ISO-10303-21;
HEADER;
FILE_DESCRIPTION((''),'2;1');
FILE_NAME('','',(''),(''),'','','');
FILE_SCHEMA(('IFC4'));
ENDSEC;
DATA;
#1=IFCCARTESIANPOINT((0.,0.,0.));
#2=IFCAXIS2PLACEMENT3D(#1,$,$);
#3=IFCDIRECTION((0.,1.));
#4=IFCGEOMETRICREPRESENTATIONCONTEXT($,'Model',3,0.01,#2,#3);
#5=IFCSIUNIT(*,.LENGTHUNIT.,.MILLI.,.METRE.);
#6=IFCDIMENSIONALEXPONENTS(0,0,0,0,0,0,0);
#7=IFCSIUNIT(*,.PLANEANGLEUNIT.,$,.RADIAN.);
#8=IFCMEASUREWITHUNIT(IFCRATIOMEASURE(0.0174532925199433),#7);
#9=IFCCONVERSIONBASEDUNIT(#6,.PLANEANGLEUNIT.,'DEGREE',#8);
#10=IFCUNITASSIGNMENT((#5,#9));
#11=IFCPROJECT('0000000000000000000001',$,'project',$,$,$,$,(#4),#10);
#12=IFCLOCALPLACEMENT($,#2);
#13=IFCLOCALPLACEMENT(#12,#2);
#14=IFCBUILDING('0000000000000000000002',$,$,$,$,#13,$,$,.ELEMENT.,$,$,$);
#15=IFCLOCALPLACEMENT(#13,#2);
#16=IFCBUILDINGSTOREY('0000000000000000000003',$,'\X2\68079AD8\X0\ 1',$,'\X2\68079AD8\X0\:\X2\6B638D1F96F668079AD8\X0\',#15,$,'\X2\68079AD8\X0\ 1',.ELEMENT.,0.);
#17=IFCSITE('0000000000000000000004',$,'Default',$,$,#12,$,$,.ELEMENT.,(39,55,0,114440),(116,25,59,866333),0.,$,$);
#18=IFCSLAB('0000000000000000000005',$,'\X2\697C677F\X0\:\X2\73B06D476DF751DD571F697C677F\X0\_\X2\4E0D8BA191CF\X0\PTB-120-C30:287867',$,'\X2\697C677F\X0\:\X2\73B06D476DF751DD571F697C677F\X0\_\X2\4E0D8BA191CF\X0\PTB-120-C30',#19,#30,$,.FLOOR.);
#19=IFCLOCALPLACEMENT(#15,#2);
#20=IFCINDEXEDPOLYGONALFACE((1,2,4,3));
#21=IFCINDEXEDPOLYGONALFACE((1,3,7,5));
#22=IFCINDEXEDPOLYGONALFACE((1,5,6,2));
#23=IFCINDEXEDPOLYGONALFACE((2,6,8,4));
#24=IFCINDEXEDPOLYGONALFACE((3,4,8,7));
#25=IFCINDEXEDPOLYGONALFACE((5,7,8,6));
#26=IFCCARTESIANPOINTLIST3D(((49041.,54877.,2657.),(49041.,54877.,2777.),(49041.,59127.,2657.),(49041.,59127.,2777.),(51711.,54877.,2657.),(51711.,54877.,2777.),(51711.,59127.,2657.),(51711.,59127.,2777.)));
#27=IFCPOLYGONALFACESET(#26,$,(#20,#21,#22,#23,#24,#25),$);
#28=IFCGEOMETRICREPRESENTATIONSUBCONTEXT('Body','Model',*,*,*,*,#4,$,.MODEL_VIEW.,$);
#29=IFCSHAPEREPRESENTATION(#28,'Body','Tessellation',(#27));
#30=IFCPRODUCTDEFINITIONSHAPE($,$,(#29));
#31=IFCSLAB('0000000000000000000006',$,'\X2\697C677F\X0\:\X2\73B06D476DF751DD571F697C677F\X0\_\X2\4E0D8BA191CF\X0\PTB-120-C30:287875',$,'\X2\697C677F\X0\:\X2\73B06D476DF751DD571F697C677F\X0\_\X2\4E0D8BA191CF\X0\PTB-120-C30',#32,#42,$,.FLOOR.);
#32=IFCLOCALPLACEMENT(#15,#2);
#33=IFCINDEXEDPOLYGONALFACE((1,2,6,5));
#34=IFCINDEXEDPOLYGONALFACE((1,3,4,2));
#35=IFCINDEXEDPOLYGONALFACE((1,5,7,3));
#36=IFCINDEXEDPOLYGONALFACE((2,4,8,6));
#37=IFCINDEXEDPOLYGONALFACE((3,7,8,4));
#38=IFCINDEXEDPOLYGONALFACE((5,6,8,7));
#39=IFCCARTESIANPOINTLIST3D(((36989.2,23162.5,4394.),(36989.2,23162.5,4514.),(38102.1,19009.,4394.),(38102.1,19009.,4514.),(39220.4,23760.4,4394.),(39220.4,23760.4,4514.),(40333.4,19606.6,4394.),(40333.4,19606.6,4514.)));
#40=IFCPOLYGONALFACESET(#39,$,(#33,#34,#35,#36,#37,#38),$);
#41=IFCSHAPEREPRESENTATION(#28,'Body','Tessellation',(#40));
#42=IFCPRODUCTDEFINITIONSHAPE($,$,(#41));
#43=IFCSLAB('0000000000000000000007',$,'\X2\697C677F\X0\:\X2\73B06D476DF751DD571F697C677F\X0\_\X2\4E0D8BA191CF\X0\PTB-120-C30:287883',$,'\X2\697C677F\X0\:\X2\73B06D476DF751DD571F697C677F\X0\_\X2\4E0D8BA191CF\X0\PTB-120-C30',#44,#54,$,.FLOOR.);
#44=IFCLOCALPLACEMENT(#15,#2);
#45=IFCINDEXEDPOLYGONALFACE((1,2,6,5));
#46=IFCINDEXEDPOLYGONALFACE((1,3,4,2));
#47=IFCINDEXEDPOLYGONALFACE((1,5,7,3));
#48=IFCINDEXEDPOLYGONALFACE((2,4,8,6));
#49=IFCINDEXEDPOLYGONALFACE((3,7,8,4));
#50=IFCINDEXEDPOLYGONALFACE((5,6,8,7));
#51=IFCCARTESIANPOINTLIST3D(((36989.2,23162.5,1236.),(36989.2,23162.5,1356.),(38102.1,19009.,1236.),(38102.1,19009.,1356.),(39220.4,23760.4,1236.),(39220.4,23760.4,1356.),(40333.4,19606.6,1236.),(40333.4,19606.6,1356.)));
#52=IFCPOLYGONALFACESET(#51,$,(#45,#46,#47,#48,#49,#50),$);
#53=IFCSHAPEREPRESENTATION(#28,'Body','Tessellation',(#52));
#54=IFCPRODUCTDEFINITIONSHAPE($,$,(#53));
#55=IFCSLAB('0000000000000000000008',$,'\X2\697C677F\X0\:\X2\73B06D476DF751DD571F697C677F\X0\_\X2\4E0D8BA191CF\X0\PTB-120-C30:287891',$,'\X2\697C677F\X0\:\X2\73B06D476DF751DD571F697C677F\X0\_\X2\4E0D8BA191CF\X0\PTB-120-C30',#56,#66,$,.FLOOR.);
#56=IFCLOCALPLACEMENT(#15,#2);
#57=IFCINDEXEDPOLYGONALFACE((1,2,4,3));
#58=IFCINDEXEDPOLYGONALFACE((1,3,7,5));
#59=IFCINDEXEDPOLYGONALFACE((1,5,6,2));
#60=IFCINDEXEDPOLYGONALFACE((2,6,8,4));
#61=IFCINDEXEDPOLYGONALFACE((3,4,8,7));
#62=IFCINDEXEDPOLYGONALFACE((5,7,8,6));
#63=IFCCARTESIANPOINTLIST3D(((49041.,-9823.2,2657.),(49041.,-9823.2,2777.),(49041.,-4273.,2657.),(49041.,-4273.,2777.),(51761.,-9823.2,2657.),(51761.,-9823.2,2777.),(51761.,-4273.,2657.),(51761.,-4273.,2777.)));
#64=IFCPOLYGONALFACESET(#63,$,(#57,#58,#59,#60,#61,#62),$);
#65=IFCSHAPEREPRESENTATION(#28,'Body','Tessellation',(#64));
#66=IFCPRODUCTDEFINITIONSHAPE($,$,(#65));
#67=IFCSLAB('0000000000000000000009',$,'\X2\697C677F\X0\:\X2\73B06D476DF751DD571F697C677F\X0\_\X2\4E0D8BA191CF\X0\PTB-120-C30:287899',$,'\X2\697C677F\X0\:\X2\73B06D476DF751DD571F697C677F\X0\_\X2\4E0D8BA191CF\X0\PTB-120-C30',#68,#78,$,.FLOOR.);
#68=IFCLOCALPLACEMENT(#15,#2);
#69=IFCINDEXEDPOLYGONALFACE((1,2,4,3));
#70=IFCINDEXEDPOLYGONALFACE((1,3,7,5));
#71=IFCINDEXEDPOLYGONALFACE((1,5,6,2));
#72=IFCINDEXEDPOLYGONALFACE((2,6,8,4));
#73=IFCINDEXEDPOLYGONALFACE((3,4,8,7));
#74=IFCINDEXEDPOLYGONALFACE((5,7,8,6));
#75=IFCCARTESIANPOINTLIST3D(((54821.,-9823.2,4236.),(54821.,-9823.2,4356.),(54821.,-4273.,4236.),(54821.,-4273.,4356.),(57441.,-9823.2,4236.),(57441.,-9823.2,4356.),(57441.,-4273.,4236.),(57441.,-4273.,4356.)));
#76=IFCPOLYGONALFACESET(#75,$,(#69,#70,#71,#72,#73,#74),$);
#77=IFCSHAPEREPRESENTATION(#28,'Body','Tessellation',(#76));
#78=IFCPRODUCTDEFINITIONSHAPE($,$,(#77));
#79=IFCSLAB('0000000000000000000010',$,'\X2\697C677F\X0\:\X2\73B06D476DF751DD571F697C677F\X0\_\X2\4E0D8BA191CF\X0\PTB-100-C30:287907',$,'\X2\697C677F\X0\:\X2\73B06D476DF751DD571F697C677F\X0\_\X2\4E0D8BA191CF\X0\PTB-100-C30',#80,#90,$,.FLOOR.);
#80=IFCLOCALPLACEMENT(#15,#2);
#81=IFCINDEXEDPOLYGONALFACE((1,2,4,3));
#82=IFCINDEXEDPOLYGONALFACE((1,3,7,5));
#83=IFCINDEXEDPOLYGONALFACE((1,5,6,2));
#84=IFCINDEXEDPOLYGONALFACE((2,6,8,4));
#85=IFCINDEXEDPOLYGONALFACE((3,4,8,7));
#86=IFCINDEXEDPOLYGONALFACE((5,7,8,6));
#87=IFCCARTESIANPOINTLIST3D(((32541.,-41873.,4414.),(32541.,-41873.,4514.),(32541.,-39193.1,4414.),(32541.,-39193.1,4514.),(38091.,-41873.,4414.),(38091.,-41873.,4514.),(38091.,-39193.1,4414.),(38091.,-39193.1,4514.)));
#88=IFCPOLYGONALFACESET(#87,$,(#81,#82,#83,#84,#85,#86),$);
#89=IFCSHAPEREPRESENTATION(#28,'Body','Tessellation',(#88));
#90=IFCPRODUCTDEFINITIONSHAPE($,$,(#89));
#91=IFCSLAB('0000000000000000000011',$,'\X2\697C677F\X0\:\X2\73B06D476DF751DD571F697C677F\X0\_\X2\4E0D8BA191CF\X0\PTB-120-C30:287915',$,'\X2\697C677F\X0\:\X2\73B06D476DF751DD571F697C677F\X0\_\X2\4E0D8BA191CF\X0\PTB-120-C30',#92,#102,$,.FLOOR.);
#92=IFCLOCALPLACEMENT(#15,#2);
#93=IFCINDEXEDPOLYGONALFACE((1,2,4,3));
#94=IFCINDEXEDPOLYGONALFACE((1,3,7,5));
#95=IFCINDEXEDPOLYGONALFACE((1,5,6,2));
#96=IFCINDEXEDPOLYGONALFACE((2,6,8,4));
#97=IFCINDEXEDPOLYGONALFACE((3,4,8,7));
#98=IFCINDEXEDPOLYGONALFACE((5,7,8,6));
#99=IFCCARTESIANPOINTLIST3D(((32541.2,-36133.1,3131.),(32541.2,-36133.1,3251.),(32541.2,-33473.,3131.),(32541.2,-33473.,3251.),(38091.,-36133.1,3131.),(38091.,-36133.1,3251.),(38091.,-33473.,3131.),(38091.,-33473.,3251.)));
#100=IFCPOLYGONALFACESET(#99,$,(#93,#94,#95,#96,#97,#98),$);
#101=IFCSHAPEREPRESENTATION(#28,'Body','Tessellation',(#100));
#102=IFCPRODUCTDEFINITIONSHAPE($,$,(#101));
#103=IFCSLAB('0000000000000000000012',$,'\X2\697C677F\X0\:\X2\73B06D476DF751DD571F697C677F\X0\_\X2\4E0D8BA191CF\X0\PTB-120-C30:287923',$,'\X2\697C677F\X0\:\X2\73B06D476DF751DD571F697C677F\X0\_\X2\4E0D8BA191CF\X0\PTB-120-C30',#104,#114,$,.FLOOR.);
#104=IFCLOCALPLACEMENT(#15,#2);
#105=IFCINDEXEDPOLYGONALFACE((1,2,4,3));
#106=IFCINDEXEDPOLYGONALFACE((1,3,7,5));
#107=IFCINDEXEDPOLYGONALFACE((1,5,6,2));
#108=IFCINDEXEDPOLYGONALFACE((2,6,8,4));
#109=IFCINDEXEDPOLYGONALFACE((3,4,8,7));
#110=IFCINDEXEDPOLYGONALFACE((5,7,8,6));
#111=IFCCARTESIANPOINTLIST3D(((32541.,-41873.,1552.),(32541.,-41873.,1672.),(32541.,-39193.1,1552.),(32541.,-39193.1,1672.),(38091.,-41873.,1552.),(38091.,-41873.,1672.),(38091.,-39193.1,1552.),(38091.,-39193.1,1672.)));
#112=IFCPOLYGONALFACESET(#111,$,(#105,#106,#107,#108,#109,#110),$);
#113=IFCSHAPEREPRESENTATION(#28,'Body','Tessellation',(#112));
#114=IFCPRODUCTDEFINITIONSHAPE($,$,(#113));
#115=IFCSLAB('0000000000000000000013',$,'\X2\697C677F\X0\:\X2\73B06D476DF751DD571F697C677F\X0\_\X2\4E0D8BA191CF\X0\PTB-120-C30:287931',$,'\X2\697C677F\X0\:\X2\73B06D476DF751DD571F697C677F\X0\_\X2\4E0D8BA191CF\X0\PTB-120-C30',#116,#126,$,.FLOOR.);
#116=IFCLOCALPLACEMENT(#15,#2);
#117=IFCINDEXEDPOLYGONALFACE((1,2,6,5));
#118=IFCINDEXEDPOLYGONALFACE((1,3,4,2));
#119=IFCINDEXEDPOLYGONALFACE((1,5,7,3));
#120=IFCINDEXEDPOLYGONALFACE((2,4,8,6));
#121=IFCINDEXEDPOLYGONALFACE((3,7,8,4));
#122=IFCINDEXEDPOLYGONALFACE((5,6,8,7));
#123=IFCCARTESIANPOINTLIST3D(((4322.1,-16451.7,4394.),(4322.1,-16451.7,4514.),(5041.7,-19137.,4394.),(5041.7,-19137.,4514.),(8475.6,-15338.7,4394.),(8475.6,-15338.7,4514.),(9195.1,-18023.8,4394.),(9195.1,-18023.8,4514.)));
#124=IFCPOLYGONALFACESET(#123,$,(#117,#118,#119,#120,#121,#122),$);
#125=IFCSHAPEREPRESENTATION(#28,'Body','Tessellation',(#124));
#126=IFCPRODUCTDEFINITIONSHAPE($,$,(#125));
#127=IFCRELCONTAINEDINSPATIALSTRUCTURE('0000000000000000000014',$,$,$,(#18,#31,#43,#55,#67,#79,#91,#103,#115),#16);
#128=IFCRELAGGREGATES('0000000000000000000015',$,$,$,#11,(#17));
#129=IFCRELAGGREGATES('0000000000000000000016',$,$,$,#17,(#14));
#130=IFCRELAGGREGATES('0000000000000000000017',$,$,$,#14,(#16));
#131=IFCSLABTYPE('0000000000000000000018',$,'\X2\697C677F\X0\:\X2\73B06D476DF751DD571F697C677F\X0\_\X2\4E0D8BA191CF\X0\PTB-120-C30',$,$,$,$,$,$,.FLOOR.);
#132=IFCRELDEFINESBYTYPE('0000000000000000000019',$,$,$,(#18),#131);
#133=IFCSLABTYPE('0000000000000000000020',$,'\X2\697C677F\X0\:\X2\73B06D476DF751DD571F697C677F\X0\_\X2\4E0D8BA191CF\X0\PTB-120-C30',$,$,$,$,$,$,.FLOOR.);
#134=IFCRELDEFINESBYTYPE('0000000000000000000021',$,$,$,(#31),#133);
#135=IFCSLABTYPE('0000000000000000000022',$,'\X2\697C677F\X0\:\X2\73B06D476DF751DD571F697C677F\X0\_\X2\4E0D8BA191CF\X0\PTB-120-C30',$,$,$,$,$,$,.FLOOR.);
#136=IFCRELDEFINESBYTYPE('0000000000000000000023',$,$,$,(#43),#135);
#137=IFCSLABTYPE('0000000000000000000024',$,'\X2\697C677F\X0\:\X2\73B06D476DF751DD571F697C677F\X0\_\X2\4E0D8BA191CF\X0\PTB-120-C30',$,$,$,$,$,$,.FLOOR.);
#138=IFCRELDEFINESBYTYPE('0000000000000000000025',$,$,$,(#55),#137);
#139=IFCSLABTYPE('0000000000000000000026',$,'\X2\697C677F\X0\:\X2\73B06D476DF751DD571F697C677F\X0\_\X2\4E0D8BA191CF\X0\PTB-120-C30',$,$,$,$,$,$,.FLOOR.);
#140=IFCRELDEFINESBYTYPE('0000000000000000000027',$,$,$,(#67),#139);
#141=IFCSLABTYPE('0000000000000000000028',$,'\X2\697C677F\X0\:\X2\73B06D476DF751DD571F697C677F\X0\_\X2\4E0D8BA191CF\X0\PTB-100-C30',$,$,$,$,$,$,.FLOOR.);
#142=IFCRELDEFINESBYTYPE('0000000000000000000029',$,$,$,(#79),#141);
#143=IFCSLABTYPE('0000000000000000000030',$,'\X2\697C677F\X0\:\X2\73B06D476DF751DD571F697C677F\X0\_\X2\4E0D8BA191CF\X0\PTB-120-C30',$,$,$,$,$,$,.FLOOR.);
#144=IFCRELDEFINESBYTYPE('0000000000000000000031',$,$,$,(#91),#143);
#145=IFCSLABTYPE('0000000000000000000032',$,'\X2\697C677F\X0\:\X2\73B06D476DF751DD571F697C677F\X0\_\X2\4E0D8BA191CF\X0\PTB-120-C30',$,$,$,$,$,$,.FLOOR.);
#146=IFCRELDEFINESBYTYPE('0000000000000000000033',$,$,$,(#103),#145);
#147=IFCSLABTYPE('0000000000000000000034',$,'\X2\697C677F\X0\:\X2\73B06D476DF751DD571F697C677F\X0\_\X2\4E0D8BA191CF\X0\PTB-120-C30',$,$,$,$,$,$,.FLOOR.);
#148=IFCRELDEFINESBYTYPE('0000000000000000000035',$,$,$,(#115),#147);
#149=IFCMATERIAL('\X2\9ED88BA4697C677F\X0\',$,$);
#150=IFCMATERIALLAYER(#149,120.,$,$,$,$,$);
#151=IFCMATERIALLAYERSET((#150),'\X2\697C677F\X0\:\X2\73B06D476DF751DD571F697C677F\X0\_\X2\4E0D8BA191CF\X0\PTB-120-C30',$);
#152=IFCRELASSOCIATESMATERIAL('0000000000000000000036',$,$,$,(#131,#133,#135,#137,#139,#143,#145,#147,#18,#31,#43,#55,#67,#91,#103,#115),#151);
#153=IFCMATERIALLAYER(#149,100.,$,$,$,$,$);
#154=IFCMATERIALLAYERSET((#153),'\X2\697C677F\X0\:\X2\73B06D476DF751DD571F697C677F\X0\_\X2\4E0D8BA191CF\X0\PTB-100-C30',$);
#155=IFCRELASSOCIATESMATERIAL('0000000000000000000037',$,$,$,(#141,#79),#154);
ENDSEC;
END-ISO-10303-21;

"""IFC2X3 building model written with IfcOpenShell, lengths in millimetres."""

from ifc_helpers import new_model, entity, si_unit, converted_unit, direction, frame, frame_2d, origin, place, context, subcontext, project, spatial, polyline, rectangle, outline, extrude, material, layer, layer_set, layer_usage, type_object, element, save


model = new_model("IFC2X3")

# Units and contexts
model_context = context("Model", 3, precision=0.01, world=origin(), true_north=direction((0.0, 1.0)))
body_context = subcontext(model_context, "Body", "Model", "MODEL_VIEW")
ifc_project = project(units=[si_unit("LENGTHUNIT", "METRE", prefix="MILLI"), converted_unit("PLANEANGLEUNIT", "DEGREE", entity("IfcRatioMeasure", 0.0174532925199433), si_unit("PLANEANGLEUNIT", "RADIAN"), dimensions=[0, 0, 0, 0, 0, 0, 0])], contexts=[model_context])

# Site, building, storey
site_placement = place(None, origin())
site = spatial("IfcSite", under=ifc_project, at=site_placement, Name="Default", CompositionType="ELEMENT", RefLatitude=(39, 55, 0, 114440), RefLongitude=(116, 25, 59, 866333), RefElevation=0.0)
building_placement = place(site_placement, origin())
building = spatial("IfcBuilding", under=site, at=building_placement, CompositionType="ELEMENT")
storey_placement = place(building_placement, origin())
storey = spatial("IfcBuildingStorey", under=building, at=storey_placement, Name="标高 1", ObjectType="标高:正负零标高", LongName="标高 1", CompositionType="ELEMENT", Elevation=0.0)

# Slabs
ifc_material = material(Name="默认楼板")
ifc_layer_1 = layer(ifc_material, 120.0)
ifc_layer_set_1 = layer_set([ifc_layer_1], Name="楼板:现浇混凝土楼板_不计量PTB-120-C30")
ifc_layer_2 = layer(ifc_material, 100.0)
ifc_layer_set_2 = layer_set([ifc_layer_2], Name="楼板:现浇混凝土楼板_不计量PTB-100-C30")
ifc_layer_usage_1 = layer_usage(ifc_layer_set_1, "AXIS3", "POSITIVE", 0.0)
slab_type_1 = type_object("IfcSlabType", Name="楼板:现浇混凝土楼板_不计量PTB-120-C30", PredefinedType="FLOOR", material=ifc_layer_set_1)
slab_1_placement = place(building_placement, origin())
element("IfcSlab", 1, at=slab_1_placement, inside=storey, type_object=slab_type_1, material=ifc_layer_usage_1, Name="楼板:现浇混凝土楼板_不计量PTB-120-C30:287867", ObjectType="楼板:现浇混凝土楼板_不计量PTB-120-C30", PredefinedType="FLOOR", context=body_context, shape_type="SweptSolid", body=[
    extrude(rectangle(XDim=4250.0, YDim=2670.0, at=frame_2d((0.0, 0.0), x_axis=(1.0, 0.0))), frame((50376.0, 57002.0, 2777.0), z_axis=(0.0, 0.0, -1.0), x_axis=(0.0, 1.0, 0.0)), (0.0, 0.0, 1.0), 120.0),
])
ifc_layer_usage_2 = layer_usage(ifc_layer_set_1, "AXIS3", "POSITIVE", 0.0)
slab_type_2 = type_object("IfcSlabType", Name="楼板:现浇混凝土楼板_不计量PTB-120-C30", PredefinedType="FLOOR", material=ifc_layer_set_1)
slab_2_placement = place(building_placement, origin())
element("IfcSlab", 2, at=slab_2_placement, inside=storey, type_object=slab_type_2, material=ifc_layer_usage_2, Name="楼板:现浇混凝土楼板_不计量PTB-120-C30:287875", ObjectType="楼板:现浇混凝土楼板_不计量PTB-120-C30", PredefinedType="FLOOR", context=body_context, shape_type="SweptSolid", body=[
    extrude(outline(polyline([(-2150.1, -1155.0), (2150.2, -1155.0), (2149.9, 1155.0), (-2150.1, 1155.0), (-2150.1, -1155.0)])), frame((38661.3, 21384.6, 4514.0), z_axis=(0.0, 0.0, -1.0), x_axis=(0.258819, -0.965926, 0.0)), (0.0, 0.0, 1.0), 120.0),
])
ifc_layer_usage_3 = layer_usage(ifc_layer_set_1, "AXIS3", "POSITIVE", 0.0)
slab_type_3 = type_object("IfcSlabType", Name="楼板:现浇混凝土楼板_不计量PTB-120-C30", PredefinedType="FLOOR", material=ifc_layer_set_1)
slab_3_placement = place(building_placement, origin())
element("IfcSlab", 3, at=slab_3_placement, inside=storey, type_object=slab_type_3, material=ifc_layer_usage_3, Name="楼板:现浇混凝土楼板_不计量PTB-120-C30:287883", ObjectType="楼板:现浇混凝土楼板_不计量PTB-120-C30", PredefinedType="FLOOR", context=body_context, shape_type="SweptSolid", body=[
    extrude(outline(polyline([(-2150.1, -1155.0), (2150.2, -1155.0), (2149.9, 1155.0), (-2150.1, 1155.0), (-2150.1, -1155.0)])), frame((38661.3, 21384.6, 1356.0), z_axis=(0.0, 0.0, -1.0), x_axis=(0.258819, -0.965926, 0.0)), (0.0, 0.0, 1.0), 120.0),
])
ifc_layer_usage_4 = layer_usage(ifc_layer_set_1, "AXIS3", "POSITIVE", 0.0)
slab_type_4 = type_object("IfcSlabType", Name="楼板:现浇混凝土楼板_不计量PTB-120-C30", PredefinedType="FLOOR", material=ifc_layer_set_1)
slab_4_placement = place(building_placement, origin())
element("IfcSlab", 4, at=slab_4_placement, inside=storey, type_object=slab_type_4, material=ifc_layer_usage_4, Name="楼板:现浇混凝土楼板_不计量PTB-120-C30:287891", ObjectType="楼板:现浇混凝土楼板_不计量PTB-120-C30", PredefinedType="FLOOR", context=body_context, shape_type="SweptSolid", body=[
    extrude(rectangle(XDim=5550.2, YDim=2720.0, at=frame_2d((0.0, 0.0), x_axis=(1.0, 0.0))), frame((50401.0, -7048.1, 2777.0), z_axis=(0.0, 0.0, -1.0), x_axis=(0.0, 1.0, 0.0)), (0.0, 0.0, 1.0), 120.0),
])
ifc_layer_usage_5 = layer_usage(ifc_layer_set_1, "AXIS3", "POSITIVE", 0.0)
slab_type_5 = type_object("IfcSlabType", Name="楼板:现浇混凝土楼板_不计量PTB-120-C30", PredefinedType="FLOOR", material=ifc_layer_set_1)
slab_5_placement = place(building_placement, origin())
element("IfcSlab", 5, at=slab_5_placement, inside=storey, type_object=slab_type_5, material=ifc_layer_usage_5, Name="楼板:现浇混凝土楼板_不计量PTB-120-C30:287899", ObjectType="楼板:现浇混凝土楼板_不计量PTB-120-C30", PredefinedType="FLOOR", context=body_context, shape_type="SweptSolid", body=[
    extrude(rectangle(XDim=5550.2, YDim=2620.0, at=frame_2d((0.0, 0.0), x_axis=(1.0, 0.0))), frame((56131.0, -7048.1, 4356.0), z_axis=(0.0, 0.0, -1.0), x_axis=(0.0, 1.0, 0.0)), (0.0, 0.0, 1.0), 120.0),
])
ifc_layer_usage_6 = layer_usage(ifc_layer_set_2, "AXIS3", "POSITIVE", 0.0)
slab_type_6 = type_object("IfcSlabType", Name="楼板:现浇混凝土楼板_不计量PTB-100-C30", PredefinedType="FLOOR", material=ifc_layer_set_2)
slab_6_placement = place(building_placement, origin())
element("IfcSlab", 6, at=slab_6_placement, inside=storey, type_object=slab_type_6, material=ifc_layer_usage_6, Name="楼板:现浇混凝土楼板_不计量PTB-100-C30:287907", ObjectType="楼板:现浇混凝土楼板_不计量PTB-100-C30", PredefinedType="FLOOR", context=body_context, shape_type="SweptSolid", body=[
    extrude(rectangle(XDim=2679.9, YDim=5550.0, at=frame_2d((0.0, 0.0), x_axis=(1.0, 0.0))), frame((35316.0, -40533.1, 4514.0), z_axis=(0.0, 0.0, -1.0), x_axis=(0.0, 1.0, 0.0)), (0.0, 0.0, 1.0), 100.0),
])
ifc_layer_usage_7 = layer_usage(ifc_layer_set_1, "AXIS3", "POSITIVE", 0.0)
slab_type_7 = type_object("IfcSlabType", Name="楼板:现浇混凝土楼板_不计量PTB-120-C30", PredefinedType="FLOOR", material=ifc_layer_set_1)
slab_7_placement = place(building_placement, origin())
element("IfcSlab", 7, at=slab_7_placement, inside=storey, type_object=slab_type_7, material=ifc_layer_usage_7, Name="楼板:现浇混凝土楼板_不计量PTB-120-C30:287915", ObjectType="楼板:现浇混凝土楼板_不计量PTB-120-C30", PredefinedType="FLOOR", context=body_context, shape_type="SweptSolid", body=[
    extrude(rectangle(XDim=2660.1, YDim=5549.8, at=frame_2d((0.0, 0.0), x_axis=(1.0, 0.0))), frame((35316.1, -34803.1, 3251.0), z_axis=(0.0, 0.0, -1.0), x_axis=(0.0, 1.0, 0.0)), (0.0, 0.0, 1.0), 120.0),
])
ifc_layer_usage_8 = layer_usage(ifc_layer_set_1, "AXIS3", "POSITIVE", 0.0)
slab_type_8 = type_object("IfcSlabType", Name="楼板:现浇混凝土楼板_不计量PTB-120-C30", PredefinedType="FLOOR", material=ifc_layer_set_1)
slab_8_placement = place(building_placement, origin())
element("IfcSlab", 8, at=slab_8_placement, inside=storey, type_object=slab_type_8, material=ifc_layer_usage_8, Name="楼板:现浇混凝土楼板_不计量PTB-120-C30:287923", ObjectType="楼板:现浇混凝土楼板_不计量PTB-120-C30", PredefinedType="FLOOR", context=body_context, shape_type="SweptSolid", body=[
    extrude(rectangle(XDim=2679.9, YDim=5550.0, at=frame_2d((0.0, 0.0), x_axis=(1.0, 0.0))), frame((35316.0, -40533.1, 1672.0), z_axis=(0.0, 0.0, -1.0), x_axis=(0.0, 1.0, 0.0)), (0.0, 0.0, 1.0), 120.0),
])
ifc_layer_usage_9 = layer_usage(ifc_layer_set_1, "AXIS3", "POSITIVE", 0.0)
slab_type_9 = type_object("IfcSlabType", Name="楼板:现浇混凝土楼板_不计量PTB-120-C30", PredefinedType="FLOOR", material=ifc_layer_set_1)
slab_9_placement = place(building_placement, origin())
element("IfcSlab", 9, at=slab_9_placement, inside=storey, type_object=slab_type_9, material=ifc_layer_usage_9, Name="楼板:现浇混凝土楼板_不计量PTB-120-C30:287931", ObjectType="楼板:现浇混凝土楼板_不计量PTB-120-C30", PredefinedType="FLOOR", context=body_context, shape_type="SweptSolid", body=[
    extrude(outline(polyline([(-1390.0, -2150.0), (1389.8, -2150.0), (1390.1, 2150.0), (-1390.0, 2150.0), (-1390.0, -2150.0)])), frame((6758.6, -17237.8, 4514.0), z_axis=(0.0, 0.0, -1.0), x_axis=(0.258817, -0.965926, 0.0)), (0.0, 0.0, 1.0), 120.0),
])

save(model, "model.ifc")
